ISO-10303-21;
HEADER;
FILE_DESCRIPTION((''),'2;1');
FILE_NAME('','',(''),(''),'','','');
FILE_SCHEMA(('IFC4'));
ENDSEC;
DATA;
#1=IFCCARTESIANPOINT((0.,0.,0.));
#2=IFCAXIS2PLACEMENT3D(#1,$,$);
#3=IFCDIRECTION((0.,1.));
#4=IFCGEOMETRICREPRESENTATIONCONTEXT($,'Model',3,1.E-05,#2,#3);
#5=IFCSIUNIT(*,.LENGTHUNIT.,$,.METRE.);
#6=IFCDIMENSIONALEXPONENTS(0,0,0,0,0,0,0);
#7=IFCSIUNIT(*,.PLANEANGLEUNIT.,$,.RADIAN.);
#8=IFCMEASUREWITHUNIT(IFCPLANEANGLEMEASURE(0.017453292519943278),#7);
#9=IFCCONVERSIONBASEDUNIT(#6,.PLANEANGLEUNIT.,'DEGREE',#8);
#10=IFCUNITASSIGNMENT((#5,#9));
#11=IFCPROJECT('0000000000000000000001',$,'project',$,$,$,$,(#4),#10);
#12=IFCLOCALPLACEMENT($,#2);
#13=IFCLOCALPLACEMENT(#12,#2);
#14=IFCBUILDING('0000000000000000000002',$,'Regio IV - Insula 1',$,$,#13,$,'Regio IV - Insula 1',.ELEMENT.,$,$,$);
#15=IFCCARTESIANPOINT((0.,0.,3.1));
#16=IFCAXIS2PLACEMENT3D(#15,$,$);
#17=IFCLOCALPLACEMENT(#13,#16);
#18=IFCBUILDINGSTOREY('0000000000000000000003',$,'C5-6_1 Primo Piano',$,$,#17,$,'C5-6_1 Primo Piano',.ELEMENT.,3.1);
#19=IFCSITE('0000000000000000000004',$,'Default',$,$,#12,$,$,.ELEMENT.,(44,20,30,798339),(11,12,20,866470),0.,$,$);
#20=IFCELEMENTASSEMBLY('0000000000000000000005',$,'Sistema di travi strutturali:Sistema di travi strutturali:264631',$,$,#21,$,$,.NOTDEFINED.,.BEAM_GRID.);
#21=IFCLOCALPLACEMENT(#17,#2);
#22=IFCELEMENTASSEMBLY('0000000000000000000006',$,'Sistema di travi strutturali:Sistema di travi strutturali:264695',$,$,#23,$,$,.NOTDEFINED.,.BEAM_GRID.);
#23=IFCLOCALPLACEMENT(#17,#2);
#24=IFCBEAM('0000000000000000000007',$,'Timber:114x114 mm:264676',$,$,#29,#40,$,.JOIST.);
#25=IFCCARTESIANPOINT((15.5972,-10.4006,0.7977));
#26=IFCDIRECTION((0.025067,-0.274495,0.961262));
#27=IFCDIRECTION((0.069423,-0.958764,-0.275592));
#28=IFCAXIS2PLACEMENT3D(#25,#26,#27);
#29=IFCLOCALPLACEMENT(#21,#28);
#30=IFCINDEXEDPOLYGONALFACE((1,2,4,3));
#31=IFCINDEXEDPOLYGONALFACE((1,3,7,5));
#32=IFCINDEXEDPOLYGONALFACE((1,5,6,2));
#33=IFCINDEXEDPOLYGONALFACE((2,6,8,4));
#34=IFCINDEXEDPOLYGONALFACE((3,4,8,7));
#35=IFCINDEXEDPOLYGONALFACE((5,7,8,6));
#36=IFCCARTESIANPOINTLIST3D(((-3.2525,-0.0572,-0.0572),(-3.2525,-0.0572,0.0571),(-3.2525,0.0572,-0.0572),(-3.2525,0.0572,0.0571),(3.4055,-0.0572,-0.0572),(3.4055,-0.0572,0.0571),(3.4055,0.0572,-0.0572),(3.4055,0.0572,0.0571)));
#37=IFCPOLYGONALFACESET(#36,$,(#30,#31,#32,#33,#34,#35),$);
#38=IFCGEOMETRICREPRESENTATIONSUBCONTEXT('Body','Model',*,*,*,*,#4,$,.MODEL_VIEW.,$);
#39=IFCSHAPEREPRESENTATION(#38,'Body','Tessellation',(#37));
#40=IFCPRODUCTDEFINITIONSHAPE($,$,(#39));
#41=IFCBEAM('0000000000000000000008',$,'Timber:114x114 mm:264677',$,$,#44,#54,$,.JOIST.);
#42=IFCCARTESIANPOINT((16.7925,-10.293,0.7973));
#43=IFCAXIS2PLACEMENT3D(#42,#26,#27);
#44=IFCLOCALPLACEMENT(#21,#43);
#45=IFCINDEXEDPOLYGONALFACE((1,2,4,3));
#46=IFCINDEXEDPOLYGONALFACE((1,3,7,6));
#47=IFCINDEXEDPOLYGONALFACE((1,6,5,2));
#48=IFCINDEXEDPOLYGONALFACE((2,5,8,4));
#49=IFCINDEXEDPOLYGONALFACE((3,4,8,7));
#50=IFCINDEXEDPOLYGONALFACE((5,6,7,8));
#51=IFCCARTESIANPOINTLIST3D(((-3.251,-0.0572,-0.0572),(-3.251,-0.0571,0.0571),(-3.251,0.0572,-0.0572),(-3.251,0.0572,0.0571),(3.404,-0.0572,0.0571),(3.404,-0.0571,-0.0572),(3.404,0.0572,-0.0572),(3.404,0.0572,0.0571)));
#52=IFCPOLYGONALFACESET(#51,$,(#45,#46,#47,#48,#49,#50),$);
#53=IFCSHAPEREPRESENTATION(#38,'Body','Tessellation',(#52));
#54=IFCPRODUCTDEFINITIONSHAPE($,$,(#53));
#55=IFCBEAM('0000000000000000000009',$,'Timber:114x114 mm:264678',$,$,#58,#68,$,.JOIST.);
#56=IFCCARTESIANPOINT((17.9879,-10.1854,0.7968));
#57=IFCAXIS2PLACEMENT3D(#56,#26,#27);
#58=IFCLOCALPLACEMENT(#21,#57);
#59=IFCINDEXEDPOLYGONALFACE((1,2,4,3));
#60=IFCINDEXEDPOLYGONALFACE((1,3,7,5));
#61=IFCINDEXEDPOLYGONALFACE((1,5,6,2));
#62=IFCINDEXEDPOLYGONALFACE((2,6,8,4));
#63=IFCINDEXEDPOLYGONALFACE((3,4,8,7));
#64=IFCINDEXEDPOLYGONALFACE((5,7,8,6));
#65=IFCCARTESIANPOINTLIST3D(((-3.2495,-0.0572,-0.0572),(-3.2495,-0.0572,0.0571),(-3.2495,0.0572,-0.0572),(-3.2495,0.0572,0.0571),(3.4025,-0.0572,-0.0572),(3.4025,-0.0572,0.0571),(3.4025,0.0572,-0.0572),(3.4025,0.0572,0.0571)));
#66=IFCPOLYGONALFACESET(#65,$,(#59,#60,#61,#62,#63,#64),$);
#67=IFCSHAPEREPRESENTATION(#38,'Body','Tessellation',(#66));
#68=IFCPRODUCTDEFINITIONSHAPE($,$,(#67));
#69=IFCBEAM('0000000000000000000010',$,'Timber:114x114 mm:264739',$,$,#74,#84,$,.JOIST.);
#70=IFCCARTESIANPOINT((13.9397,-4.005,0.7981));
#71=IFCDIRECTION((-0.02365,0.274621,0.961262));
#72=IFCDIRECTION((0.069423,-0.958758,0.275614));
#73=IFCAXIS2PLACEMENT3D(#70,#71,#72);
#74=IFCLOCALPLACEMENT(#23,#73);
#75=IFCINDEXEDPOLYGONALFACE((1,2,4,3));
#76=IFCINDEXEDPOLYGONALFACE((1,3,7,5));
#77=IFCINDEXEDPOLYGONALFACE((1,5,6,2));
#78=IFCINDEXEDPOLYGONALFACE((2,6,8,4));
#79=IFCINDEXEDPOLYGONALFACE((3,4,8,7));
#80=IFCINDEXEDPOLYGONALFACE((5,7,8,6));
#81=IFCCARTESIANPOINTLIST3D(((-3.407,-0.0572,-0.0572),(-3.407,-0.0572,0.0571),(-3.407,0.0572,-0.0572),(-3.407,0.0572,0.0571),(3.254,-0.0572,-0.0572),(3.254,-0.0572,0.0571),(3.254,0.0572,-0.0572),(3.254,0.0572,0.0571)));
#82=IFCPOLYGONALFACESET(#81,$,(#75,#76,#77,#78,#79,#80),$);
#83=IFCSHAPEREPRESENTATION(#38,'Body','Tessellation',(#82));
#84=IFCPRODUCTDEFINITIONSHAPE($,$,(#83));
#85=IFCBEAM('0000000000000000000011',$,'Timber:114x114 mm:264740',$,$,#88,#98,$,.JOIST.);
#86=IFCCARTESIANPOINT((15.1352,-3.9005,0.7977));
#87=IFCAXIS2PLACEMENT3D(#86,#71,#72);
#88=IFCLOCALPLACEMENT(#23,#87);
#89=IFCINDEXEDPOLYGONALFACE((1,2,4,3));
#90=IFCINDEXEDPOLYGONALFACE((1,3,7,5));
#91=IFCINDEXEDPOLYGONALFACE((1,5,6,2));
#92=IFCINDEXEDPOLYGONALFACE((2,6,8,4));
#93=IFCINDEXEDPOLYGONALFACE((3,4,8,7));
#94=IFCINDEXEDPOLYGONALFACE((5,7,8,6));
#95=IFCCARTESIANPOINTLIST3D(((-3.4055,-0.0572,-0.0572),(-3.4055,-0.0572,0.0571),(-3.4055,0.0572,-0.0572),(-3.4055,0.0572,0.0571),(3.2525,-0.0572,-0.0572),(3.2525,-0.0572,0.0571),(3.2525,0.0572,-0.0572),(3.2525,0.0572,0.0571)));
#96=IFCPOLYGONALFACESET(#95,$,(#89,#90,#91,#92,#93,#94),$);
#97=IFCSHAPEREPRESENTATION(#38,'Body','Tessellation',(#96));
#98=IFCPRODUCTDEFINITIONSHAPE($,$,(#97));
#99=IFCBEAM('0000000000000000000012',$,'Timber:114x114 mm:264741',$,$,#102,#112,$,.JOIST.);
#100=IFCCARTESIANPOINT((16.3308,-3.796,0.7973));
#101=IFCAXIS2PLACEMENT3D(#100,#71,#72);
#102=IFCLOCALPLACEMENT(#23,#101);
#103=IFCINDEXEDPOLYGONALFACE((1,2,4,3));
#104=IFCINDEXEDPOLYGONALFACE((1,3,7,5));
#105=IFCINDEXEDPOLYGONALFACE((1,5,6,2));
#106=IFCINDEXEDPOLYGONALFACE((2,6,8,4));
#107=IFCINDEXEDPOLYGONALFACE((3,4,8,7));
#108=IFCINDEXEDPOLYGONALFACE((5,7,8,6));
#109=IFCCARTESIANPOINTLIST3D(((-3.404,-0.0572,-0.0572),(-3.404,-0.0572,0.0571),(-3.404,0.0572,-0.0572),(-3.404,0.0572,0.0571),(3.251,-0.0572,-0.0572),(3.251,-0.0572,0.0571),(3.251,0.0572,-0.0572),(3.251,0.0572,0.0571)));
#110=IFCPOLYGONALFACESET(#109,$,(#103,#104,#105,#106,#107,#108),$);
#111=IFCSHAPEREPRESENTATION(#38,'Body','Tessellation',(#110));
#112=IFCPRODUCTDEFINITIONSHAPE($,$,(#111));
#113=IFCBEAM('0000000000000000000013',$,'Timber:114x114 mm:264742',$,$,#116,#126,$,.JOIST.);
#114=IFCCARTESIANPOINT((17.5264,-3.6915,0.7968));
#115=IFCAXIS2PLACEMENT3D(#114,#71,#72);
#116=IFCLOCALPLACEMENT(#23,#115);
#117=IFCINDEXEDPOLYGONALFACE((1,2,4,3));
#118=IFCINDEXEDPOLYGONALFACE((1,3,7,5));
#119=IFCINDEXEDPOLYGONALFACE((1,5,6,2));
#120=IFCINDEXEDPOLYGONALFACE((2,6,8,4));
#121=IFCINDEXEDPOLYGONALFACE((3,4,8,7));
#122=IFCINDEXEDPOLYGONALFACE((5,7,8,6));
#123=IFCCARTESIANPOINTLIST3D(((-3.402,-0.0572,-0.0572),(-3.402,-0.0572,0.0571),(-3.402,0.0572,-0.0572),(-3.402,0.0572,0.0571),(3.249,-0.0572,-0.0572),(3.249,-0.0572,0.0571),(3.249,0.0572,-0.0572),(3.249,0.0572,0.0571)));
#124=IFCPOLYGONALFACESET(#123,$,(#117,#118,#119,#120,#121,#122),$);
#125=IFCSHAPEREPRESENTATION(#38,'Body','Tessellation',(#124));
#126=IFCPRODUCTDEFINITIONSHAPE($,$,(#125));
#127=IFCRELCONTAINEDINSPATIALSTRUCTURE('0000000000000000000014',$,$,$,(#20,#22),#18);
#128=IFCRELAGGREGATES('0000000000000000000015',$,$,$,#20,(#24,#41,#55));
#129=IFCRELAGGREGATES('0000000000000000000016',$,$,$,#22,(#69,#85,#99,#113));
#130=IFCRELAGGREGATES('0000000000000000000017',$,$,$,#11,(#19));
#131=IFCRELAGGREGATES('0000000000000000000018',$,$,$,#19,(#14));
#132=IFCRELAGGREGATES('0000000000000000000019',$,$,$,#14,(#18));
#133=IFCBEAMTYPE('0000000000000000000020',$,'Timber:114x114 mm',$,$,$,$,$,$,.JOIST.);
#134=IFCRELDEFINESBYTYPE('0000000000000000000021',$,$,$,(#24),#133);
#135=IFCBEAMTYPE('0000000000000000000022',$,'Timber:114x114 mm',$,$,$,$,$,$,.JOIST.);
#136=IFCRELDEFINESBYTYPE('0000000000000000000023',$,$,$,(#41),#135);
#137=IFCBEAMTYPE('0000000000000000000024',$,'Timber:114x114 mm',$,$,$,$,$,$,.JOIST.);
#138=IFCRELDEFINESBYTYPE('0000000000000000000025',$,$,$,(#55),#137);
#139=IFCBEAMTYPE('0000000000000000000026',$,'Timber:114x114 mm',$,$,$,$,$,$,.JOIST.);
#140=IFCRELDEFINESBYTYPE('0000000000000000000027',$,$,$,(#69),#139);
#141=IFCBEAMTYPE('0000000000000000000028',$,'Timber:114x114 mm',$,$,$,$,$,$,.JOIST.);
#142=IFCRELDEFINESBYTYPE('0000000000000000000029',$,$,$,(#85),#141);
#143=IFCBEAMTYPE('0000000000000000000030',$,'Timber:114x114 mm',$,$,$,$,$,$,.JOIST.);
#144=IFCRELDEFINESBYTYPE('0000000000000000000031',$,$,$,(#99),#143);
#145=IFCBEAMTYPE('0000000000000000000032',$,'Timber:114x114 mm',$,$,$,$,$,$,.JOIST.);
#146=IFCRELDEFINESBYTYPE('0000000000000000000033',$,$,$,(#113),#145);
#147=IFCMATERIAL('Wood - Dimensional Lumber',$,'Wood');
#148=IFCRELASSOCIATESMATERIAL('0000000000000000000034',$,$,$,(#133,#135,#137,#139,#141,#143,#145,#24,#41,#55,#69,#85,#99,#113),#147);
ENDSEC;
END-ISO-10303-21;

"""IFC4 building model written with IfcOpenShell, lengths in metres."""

from ifc_helpers import new_model, entity, si_unit, converted_unit, direction, frame, origin, origin_2d_with_axis, place, context, subcontext, project, spatial, rectangle, extrude, source, transform, mapped, material, material_profile, profile_set, profile_usage, type_object, type_shapes, element, aggregate, save


model = new_model("IFC4")

# Units and contexts
model_context = context("Model", 3, precision=1e-05, world=origin(), true_north=direction((0.0, 1.0)))
body_context = subcontext(model_context, "Body", "Model", "MODEL_VIEW")
ifc_project = project(units=[si_unit("LENGTHUNIT", "METRE"), converted_unit("PLANEANGLEUNIT", "DEGREE", entity("IfcPlaneAngleMeasure", 0.017453292519943278), si_unit("PLANEANGLEUNIT", "RADIAN"), dimensions=[0, 0, 0, 0, 0, 0, 0])], contexts=[model_context])

# Site, building, storey
site_placement = place(None, origin())
site = spatial("IfcSite", under=ifc_project, at=site_placement, Name="Default", CompositionType="ELEMENT", RefLatitude=(44, 20, 30, 798339), RefLongitude=(11, 12, 20, 866470), RefElevation=0.0)
building_placement = place(site_placement, origin())
building = spatial("IfcBuilding", under=site, at=building_placement, Name="Regio IV - Insula 1", LongName="Regio IV - Insula 1", CompositionType="ELEMENT")
storey_placement = place(building_placement, frame((0.0, 0.0, 3.1)))
storey = spatial("IfcBuildingStorey", under=building, at=storey_placement, Name="C5-6_1 Primo Piano", LongName="C5-6_1 Primo Piano", CompositionType="ELEMENT", Elevation=3.1)

# Element assembly
assembly_1_placement = place(storey_placement, origin())
assembly_1 = element("IfcElementAssembly", 1, at=assembly_1_placement, inside=storey, Name="Sistema di travi strutturali:Sistema di travi strutturali:264631", AssemblyPlace="NOTDEFINED", PredefinedType="BEAM_GRID")
ifc_material = material(Name="Wood - Dimensional Lumber", Category="Wood")
ifc_material_profile_1 = material_profile(ifc_material, rectangle(XDim=5.294, YDim=0.1143, at=origin_2d_with_axis()), Name="114x114 mm")
ifc_profile_set_1 = profile_set([ifc_material_profile_1], Name="114x114 mm")
ifc_profile_usage_1 = profile_usage(ifc_profile_set_1, cardinal=8)

# Element assembly
assembly_2_placement = place(storey_placement, origin())
assembly_2 = element("IfcElementAssembly", 2, at=assembly_2_placement, inside=storey, Name="Sistema di travi strutturali:Sistema di travi strutturali:264695", AssemblyPlace="NOTDEFINED", PredefinedType="BEAM_GRID")

# Beams
beam_type_1 = type_object("IfcBeamType", Name="Timber:114x114 mm", PredefinedType="JOIST", material=ifc_profile_set_1)
shared_shape_1 = source(origin(), body_context, "Body", "SweptSolid", [
    extrude(rectangle(XDim=6.658, YDim=0.1143, at=origin_2d_with_axis()), frame((0.0765, 0.0, -0.0572), z_axis=(0.0, 0.0, 1.0), x_axis=(-1.0, 0.0, 0.0)), (0.0, 0.0, 1.0), 0.1143),
])
type_shapes(beam_type_1, [shared_shape_1])
beam_1_placement = place(assembly_1_placement, frame((15.5972, -10.4006, 0.7977), z_axis=(0.025067, -0.274495, 0.961262), x_axis=(0.069423, -0.958764, -0.275592)))
beam_1 = element("IfcBeam", 3, at=beam_1_placement, type_object=beam_type_1, material=ifc_profile_usage_1, Name="Timber:114x114 mm:264676", PredefinedType="JOIST", context=body_context, shape_type="MappedRepresentation", body=[
    mapped(shared_shape_1, transform((0.0, 0.0, 0.0), scale=1.0)),
])
beam_type_2 = type_object("IfcBeamType", Name="Timber:114x114 mm", PredefinedType="JOIST", material=ifc_profile_set_1)
shared_shape_2 = source(origin(), body_context, "Body", "SweptSolid", [
    extrude(rectangle(XDim=6.655, YDim=0.1143, at=origin_2d_with_axis()), frame((0.0765, 0.0, -0.0572), z_axis=(0.0, 0.0, 1.0), x_axis=(-1.0, 0.0, 0.0)), (0.0, 0.0, 1.0), 0.1143),
])
type_shapes(beam_type_2, [shared_shape_2])
beam_2_placement = place(assembly_1_placement, frame((16.7925, -10.293, 0.7973), z_axis=(0.025067, -0.274495, 0.961262), x_axis=(0.069423, -0.958764, -0.275592)))
beam_2 = element("IfcBeam", 4, at=beam_2_placement, type_object=beam_type_2, material=ifc_profile_usage_1, Name="Timber:114x114 mm:264677", PredefinedType="JOIST", context=body_context, shape_type="MappedRepresentation", body=[
    mapped(shared_shape_2, transform((0.0, 0.0, 0.0), scale=1.0)),
])
beam_type_3 = type_object("IfcBeamType", Name="Timber:114x114 mm", PredefinedType="JOIST", material=ifc_profile_set_1)
shared_shape_3 = source(origin(), body_context, "Body", "SweptSolid", [
    extrude(rectangle(XDim=6.652, YDim=0.1143, at=origin_2d_with_axis()), frame((0.0765, 0.0, -0.0572), z_axis=(0.0, 0.0, 1.0), x_axis=(-1.0, 0.0, 0.0)), (0.0, 0.0, 1.0), 0.1143),
])
type_shapes(beam_type_3, [shared_shape_3])
beam_3_placement = place(assembly_1_placement, frame((17.9879, -10.1854, 0.7968), z_axis=(0.025067, -0.274495, 0.961262), x_axis=(0.069423, -0.958764, -0.275592)))
beam_3 = element("IfcBeam", 5, at=beam_3_placement, type_object=beam_type_3, material=ifc_profile_usage_1, Name="Timber:114x114 mm:264678", PredefinedType="JOIST", context=body_context, shape_type="MappedRepresentation", body=[
    mapped(shared_shape_3, transform((0.0, 0.0, 0.0), scale=1.0)),
])
aggregate(assembly_1, [beam_1, beam_2, beam_3])
beam_type_4 = type_object("IfcBeamType", Name="Timber:114x114 mm", PredefinedType="JOIST", material=ifc_profile_set_1)
shared_shape_4 = source(origin(), body_context, "Body", "SweptSolid", [
    extrude(rectangle(XDim=6.661, YDim=0.1143, at=origin_2d_with_axis()), frame((-0.0765, 0.0, -0.0572), z_axis=(0.0, 0.0, 1.0), x_axis=(-1.0, 0.0, 0.0)), (0.0, 0.0, 1.0), 0.1143),
])
type_shapes(beam_type_4, [shared_shape_4])
beam_4_placement = place(assembly_2_placement, frame((13.9397, -4.005, 0.7981), z_axis=(-0.02365, 0.274621, 0.961262), x_axis=(0.069423, -0.958758, 0.275614)))
beam_4 = element("IfcBeam", 6, at=beam_4_placement, type_object=beam_type_4, material=ifc_profile_usage_1, Name="Timber:114x114 mm:264739", PredefinedType="JOIST", context=body_context, shape_type="MappedRepresentation", body=[
    mapped(shared_shape_4, transform((0.0, 0.0, 0.0), scale=1.0)),
])
beam_type_5 = type_object("IfcBeamType", Name="Timber:114x114 mm", PredefinedType="JOIST", material=ifc_profile_set_1)
shared_shape_5 = source(origin(), body_context, "Body", "SweptSolid", [
    extrude(rectangle(XDim=6.658, YDim=0.1143, at=origin_2d_with_axis()), frame((-0.0765, 0.0, -0.0572), z_axis=(0.0, 0.0, 1.0), x_axis=(-1.0, 0.0, 0.0)), (0.0, 0.0, 1.0), 0.1143),
])
type_shapes(beam_type_5, [shared_shape_5])
beam_5_placement = place(assembly_2_placement, frame((15.1352, -3.9005, 0.7977), z_axis=(-0.02365, 0.274621, 0.961262), x_axis=(0.069423, -0.958758, 0.275614)))
beam_5 = element("IfcBeam", 7, at=beam_5_placement, type_object=beam_type_5, material=ifc_profile_usage_1, Name="Timber:114x114 mm:264740", PredefinedType="JOIST", context=body_context, shape_type="MappedRepresentation", body=[
    mapped(shared_shape_5, transform((0.0, 0.0, 0.0), scale=1.0)),
])
beam_type_6 = type_object("IfcBeamType", Name="Timber:114x114 mm", PredefinedType="JOIST", material=ifc_profile_set_1)
shared_shape_6 = source(origin(), body_context, "Body", "SweptSolid", [
    extrude(rectangle(XDim=6.655, YDim=0.1143, at=origin_2d_with_axis()), frame((-0.0765, 0.0, -0.0572), z_axis=(0.0, 0.0, 1.0), x_axis=(-1.0, 0.0, 0.0)), (0.0, 0.0, 1.0), 0.1143),
])
type_shapes(beam_type_6, [shared_shape_6])
beam_6_placement = place(assembly_2_placement, frame((16.3308, -3.796, 0.7973), z_axis=(-0.02365, 0.274621, 0.961262), x_axis=(0.069423, -0.958758, 0.275614)))
beam_6 = element("IfcBeam", 8, at=beam_6_placement, type_object=beam_type_6, material=ifc_profile_usage_1, Name="Timber:114x114 mm:264741", PredefinedType="JOIST", context=body_context, shape_type="MappedRepresentation", body=[
    mapped(shared_shape_6, transform((0.0, 0.0, 0.0), scale=1.0)),
])
beam_type_7 = type_object("IfcBeamType", Name="Timber:114x114 mm", PredefinedType="JOIST", material=ifc_profile_set_1)
shared_shape_7 = source(origin(), body_context, "Body", "SweptSolid", [
    extrude(rectangle(XDim=6.651, YDim=0.1143, at=origin_2d_with_axis()), frame((-0.0765, 0.0, -0.0572), z_axis=(0.0, 0.0, 1.0), x_axis=(-1.0, 0.0, 0.0)), (0.0, 0.0, 1.0), 0.1143),
])
type_shapes(beam_type_7, [shared_shape_7])
beam_7_placement = place(assembly_2_placement, frame((17.5264, -3.6915, 0.7968), z_axis=(-0.02365, 0.274621, 0.961262), x_axis=(0.069423, -0.958758, 0.275614)))
beam_7 = element("IfcBeam", 9, at=beam_7_placement, type_object=beam_type_7, material=ifc_profile_usage_1, Name="Timber:114x114 mm:264742", PredefinedType="JOIST", context=body_context, shape_type="MappedRepresentation", body=[
    mapped(shared_shape_7, transform((0.0, 0.0, 0.0), scale=1.0)),
])
aggregate(assembly_2, [beam_4, beam_5, beam_6, beam_7])

save(model, "model.ifc")
